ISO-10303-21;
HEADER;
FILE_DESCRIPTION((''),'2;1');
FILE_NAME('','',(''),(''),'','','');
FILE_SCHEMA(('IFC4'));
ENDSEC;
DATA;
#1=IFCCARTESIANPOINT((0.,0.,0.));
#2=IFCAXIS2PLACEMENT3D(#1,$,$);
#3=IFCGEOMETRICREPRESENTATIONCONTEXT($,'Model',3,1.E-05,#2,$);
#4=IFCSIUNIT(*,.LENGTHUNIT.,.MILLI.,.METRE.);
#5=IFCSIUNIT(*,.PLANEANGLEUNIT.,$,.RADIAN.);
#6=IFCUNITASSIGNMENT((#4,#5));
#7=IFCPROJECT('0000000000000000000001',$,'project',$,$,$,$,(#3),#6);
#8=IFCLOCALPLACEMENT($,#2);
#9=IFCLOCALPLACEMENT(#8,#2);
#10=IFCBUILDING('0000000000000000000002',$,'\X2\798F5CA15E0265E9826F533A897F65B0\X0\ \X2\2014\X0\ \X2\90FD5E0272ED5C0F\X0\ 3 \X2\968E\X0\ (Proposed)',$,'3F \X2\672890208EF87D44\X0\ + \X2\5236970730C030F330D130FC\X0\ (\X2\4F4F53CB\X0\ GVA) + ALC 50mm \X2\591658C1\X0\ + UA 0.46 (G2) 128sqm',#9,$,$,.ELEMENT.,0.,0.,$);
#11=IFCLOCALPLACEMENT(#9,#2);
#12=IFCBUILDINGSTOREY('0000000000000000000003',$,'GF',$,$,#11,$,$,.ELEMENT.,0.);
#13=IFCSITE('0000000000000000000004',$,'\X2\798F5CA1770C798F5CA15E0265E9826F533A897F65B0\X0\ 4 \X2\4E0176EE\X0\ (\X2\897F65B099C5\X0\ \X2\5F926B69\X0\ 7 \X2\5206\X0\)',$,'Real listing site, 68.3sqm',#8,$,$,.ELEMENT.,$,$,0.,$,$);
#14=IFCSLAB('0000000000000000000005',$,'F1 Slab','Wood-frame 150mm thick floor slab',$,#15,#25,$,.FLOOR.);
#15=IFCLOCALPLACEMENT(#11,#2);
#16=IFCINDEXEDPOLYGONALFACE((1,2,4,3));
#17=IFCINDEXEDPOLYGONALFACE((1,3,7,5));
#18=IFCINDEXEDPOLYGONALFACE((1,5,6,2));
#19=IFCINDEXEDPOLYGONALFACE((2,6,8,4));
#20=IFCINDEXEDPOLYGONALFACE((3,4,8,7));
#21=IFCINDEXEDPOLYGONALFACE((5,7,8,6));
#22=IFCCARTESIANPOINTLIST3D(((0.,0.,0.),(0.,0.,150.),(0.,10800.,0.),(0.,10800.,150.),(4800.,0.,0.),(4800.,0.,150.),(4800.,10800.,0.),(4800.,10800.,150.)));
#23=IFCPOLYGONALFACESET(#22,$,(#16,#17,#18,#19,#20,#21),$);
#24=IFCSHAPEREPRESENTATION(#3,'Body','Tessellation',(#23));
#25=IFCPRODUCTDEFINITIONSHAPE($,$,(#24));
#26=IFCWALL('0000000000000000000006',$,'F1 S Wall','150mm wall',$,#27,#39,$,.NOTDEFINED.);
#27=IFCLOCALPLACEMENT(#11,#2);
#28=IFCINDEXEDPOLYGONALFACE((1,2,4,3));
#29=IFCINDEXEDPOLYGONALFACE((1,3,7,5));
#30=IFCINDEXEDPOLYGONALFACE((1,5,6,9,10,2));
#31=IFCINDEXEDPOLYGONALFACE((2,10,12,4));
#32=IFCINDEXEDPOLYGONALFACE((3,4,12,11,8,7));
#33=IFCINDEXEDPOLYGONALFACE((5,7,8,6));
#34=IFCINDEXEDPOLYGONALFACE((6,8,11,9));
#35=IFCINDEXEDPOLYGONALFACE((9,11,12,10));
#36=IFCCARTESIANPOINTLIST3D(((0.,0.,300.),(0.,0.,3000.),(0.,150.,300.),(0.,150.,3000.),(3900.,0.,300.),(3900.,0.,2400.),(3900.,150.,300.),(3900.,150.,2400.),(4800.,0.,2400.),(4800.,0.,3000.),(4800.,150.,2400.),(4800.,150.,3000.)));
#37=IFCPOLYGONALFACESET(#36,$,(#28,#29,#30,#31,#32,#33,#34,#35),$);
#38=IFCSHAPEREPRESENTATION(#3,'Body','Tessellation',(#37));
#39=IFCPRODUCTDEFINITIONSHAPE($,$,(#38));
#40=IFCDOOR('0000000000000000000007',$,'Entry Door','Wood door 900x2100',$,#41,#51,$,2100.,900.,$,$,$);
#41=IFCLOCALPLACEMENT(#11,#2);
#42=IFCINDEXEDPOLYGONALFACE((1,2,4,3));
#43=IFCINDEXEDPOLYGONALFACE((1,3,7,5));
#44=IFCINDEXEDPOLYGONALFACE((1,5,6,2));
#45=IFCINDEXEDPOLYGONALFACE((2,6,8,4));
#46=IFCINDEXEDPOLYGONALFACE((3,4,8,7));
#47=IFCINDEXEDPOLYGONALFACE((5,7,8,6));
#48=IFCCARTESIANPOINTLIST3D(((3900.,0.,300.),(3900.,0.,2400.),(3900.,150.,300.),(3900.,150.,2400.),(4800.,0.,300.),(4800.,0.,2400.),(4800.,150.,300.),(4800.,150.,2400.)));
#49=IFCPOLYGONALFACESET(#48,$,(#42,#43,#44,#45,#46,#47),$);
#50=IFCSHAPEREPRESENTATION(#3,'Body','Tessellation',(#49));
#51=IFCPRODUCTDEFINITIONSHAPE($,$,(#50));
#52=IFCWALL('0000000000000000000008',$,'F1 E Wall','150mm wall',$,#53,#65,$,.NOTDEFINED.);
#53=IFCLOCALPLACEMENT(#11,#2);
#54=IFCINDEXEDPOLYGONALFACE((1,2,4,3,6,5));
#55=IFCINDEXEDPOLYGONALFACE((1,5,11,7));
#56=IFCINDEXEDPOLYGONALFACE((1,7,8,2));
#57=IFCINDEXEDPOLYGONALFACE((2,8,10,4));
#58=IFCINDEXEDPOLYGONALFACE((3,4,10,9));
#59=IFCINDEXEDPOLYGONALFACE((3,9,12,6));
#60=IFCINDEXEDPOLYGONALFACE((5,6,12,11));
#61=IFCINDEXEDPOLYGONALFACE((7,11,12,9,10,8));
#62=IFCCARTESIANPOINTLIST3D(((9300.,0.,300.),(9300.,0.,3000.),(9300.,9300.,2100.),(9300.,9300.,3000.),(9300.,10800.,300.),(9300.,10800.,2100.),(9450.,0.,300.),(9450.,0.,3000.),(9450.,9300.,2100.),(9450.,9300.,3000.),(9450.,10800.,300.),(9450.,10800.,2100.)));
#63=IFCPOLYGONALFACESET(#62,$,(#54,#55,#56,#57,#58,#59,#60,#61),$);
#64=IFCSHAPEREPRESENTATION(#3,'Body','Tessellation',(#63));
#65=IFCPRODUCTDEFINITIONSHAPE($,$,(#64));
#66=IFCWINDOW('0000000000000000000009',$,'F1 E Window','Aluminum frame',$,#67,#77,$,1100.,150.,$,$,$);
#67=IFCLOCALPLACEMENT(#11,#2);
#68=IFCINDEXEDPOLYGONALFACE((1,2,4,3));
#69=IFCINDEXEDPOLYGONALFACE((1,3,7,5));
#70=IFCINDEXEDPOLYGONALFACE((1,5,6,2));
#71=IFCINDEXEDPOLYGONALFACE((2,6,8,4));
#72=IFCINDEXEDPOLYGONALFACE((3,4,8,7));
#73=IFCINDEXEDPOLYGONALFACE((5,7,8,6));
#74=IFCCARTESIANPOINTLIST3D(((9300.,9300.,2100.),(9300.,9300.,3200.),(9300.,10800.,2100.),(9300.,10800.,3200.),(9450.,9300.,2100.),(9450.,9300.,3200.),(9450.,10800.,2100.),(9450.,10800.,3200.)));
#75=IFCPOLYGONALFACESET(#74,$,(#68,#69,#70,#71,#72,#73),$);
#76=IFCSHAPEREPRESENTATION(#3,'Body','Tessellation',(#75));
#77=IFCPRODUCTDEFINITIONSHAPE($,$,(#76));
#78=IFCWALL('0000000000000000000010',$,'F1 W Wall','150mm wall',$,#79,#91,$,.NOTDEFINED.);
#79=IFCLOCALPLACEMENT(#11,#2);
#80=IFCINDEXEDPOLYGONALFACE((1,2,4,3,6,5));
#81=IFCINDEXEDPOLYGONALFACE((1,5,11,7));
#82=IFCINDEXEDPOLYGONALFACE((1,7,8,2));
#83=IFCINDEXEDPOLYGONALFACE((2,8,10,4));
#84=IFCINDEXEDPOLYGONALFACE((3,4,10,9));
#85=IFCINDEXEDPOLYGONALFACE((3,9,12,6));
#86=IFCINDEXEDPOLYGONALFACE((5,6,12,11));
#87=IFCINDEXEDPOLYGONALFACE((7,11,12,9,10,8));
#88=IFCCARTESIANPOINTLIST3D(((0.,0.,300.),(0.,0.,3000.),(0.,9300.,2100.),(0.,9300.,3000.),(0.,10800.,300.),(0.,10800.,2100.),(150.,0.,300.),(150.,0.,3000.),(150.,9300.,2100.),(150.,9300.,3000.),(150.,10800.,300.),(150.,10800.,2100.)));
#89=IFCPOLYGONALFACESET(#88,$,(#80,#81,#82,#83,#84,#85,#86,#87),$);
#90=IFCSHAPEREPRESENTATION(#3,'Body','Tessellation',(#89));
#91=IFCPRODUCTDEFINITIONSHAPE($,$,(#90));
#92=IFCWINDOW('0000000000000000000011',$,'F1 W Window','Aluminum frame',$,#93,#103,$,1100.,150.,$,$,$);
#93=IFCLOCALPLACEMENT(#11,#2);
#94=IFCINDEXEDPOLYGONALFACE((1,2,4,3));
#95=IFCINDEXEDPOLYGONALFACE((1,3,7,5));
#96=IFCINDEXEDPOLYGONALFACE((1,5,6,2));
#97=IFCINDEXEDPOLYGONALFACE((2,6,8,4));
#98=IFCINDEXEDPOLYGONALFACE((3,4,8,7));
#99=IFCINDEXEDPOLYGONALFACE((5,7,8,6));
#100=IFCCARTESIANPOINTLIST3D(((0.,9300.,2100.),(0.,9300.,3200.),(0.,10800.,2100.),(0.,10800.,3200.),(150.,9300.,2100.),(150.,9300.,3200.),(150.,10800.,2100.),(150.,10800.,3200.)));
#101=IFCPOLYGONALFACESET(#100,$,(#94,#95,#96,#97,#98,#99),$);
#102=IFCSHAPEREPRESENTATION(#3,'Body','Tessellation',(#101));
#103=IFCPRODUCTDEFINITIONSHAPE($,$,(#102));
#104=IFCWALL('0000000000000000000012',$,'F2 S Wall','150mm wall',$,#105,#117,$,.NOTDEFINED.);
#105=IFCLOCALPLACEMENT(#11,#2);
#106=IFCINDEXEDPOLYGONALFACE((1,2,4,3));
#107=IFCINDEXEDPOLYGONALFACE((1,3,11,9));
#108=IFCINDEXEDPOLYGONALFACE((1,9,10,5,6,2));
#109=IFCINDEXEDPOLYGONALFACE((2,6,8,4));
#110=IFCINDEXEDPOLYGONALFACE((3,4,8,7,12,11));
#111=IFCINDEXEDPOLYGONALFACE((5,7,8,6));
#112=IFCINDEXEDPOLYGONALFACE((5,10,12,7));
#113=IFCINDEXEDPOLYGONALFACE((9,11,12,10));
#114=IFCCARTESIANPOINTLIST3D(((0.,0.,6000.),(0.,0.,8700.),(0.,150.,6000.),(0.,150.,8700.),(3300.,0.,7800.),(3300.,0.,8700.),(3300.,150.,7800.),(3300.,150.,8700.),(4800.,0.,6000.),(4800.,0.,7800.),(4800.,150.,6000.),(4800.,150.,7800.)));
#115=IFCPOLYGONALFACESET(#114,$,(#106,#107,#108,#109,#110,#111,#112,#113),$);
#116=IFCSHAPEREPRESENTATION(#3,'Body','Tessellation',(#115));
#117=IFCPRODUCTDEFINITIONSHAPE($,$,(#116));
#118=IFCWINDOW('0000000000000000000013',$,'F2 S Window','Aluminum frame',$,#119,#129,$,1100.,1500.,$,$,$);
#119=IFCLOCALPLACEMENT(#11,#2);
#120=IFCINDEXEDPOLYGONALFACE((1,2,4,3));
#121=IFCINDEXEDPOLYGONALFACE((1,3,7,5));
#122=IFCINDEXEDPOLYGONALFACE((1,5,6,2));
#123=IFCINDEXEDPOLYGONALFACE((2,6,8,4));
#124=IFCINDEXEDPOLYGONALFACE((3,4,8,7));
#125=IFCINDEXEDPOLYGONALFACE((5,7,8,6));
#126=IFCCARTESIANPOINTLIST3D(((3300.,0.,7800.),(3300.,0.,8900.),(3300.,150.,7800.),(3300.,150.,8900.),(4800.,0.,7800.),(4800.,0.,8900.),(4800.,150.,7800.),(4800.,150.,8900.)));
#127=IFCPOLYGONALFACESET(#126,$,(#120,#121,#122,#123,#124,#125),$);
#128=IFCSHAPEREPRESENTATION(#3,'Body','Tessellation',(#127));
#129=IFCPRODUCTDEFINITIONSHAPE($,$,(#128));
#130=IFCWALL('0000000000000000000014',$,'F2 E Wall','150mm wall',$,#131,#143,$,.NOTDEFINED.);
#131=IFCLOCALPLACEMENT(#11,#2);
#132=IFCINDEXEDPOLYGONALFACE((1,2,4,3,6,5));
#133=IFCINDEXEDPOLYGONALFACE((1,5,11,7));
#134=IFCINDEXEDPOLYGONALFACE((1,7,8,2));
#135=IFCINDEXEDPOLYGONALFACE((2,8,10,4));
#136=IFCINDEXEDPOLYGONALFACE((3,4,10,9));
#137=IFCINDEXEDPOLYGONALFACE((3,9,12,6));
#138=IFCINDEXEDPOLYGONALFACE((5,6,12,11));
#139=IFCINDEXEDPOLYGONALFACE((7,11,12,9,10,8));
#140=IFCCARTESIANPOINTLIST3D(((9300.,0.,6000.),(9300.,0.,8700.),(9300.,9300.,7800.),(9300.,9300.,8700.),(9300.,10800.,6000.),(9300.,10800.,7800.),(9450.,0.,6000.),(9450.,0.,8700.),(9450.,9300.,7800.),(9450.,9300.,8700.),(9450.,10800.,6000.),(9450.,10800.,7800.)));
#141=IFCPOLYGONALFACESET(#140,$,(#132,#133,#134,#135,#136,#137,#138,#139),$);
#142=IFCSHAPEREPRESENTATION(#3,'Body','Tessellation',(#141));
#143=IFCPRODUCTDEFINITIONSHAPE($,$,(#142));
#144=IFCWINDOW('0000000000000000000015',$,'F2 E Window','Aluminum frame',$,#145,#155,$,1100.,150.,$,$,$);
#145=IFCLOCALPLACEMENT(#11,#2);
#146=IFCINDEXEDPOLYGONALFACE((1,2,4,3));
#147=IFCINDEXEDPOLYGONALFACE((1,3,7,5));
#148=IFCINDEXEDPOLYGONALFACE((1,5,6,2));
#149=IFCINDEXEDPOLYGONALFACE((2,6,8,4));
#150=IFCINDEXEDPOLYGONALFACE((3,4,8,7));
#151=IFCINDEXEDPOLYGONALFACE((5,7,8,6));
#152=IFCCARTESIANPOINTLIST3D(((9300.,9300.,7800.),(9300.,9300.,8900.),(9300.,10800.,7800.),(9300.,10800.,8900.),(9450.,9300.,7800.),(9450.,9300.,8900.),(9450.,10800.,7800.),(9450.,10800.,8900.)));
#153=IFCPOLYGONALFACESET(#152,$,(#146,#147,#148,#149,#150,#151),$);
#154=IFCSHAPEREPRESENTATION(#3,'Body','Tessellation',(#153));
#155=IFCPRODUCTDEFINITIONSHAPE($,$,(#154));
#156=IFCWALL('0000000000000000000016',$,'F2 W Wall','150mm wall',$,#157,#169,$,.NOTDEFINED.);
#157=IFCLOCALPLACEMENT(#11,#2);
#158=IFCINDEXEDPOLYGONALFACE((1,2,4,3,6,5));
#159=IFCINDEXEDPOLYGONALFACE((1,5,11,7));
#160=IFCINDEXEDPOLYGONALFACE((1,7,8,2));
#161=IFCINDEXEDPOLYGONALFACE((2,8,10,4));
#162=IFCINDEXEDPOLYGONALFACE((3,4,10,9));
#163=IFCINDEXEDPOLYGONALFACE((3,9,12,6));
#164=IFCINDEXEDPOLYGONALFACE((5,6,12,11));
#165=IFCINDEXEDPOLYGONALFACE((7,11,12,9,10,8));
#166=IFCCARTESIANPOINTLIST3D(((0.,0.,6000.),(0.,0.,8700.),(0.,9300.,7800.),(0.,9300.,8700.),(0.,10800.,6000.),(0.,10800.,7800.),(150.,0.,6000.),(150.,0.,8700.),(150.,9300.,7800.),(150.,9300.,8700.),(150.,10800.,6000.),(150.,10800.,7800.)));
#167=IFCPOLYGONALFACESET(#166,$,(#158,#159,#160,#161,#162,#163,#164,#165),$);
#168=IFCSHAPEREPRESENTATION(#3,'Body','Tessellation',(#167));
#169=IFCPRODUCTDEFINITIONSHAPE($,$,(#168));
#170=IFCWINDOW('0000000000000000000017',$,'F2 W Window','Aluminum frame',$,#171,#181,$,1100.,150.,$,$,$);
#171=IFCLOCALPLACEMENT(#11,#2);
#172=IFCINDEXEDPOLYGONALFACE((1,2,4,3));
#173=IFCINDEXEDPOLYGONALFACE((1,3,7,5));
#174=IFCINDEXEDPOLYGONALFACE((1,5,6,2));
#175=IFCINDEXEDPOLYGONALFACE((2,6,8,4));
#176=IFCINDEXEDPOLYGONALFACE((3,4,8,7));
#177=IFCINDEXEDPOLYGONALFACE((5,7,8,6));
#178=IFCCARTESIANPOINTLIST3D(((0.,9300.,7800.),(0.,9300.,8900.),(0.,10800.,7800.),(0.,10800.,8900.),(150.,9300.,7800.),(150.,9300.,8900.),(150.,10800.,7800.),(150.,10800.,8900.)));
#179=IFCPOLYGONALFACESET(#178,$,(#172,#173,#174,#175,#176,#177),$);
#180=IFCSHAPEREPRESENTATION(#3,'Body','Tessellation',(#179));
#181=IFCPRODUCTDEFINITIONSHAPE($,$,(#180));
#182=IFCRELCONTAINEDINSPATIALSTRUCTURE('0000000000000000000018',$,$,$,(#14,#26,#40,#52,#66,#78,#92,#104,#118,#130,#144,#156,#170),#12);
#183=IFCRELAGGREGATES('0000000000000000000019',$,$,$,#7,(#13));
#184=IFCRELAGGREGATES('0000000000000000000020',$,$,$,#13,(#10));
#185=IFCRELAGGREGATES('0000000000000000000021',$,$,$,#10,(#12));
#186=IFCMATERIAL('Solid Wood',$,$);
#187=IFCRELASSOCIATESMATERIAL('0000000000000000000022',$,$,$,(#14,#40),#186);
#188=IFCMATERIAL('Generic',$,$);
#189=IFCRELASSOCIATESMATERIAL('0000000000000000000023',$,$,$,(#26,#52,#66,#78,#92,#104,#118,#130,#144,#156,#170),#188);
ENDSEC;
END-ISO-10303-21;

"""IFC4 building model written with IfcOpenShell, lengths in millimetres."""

from ifc_helpers import new_model, si_unit, frame, frame_2d, origin, place, context, project, spatial, rectangle, extrude, material, element, fill, save


model = new_model("IFC4")

# Units and contexts
model_context = context("Model", 3, precision=1e-05, world=origin())
ifc_project = project(units=[si_unit("LENGTHUNIT", "METRE", prefix="MILLI"), si_unit("PLANEANGLEUNIT", "RADIAN")], contexts=[model_context])

# Site, building, storey
site_placement = place(None, origin())
site = spatial("IfcSite", under=ifc_project, at=site_placement, Name="福岡県福岡市早良区西新 4 丁目 (西新駅 徒歩 7 分)", ObjectType="Real listing site, 68.3sqm", CompositionType="ELEMENT", RefElevation=0.0)
building_placement = place(site_placement, origin())
building = spatial("IfcBuilding", under=site, at=building_placement, Name="福岡市早良区西新 — 都市狭小 3 階 (Proposed)", ObjectType="3F 木造軸組 + 制震ダンパー (住友 GVA) + ALC 50mm 外壁 + UA 0.46 (G2) 128sqm", CompositionType="ELEMENT", ElevationOfRefHeight=0.0, ElevationOfTerrain=0.0)
storey_placement = place(building_placement, origin())
storey = spatial("IfcBuildingStorey", under=building, at=storey_placement, Name="GF", CompositionType="ELEMENT", Elevation=0.0)

# Slab
ifc_material_1 = material(Name="Solid Wood")
slab_1_placement = place(storey_placement, origin())
element("IfcSlab", 1, at=slab_1_placement, inside=storey, material=ifc_material_1, Name="F1 Slab", Description="Wood-frame 150mm thick floor slab", PredefinedType="FLOOR", context=model_context, shape_type="SweptSolid", body=[
    extrude(rectangle(XDim=4800.0, YDim=10800.0, at=frame_2d((2400.0, 5400.0))), origin(), (0.0, 0.0, 1.0), 150.0),
])

# Wall, opening, door
ifc_material_2 = material(Name="Generic")
wall_1_placement = place(storey_placement, frame((0.0, 0.0, 150.0)))
wall_1 = element("IfcWall", 2, at=wall_1_placement, inside=storey, material=ifc_material_2, Name="F1 S Wall", Description="150mm wall", PredefinedType="NOTDEFINED", context=model_context, shape_type="SweptSolid", body=[
    extrude(rectangle(XDim=4800.0, YDim=150.0, at=frame_2d((2400.0, 75.0))), frame((0.0, 0.0, 150.0)), (0.0, 0.0, 1.0), 2700.0),
])
opening_1_placement = place(storey_placement, frame((1950.0, 0.0, 150.0)))
opening_1 = element("IfcOpeningElement", 3, at=opening_1_placement, cuts=wall_1, PredefinedType="NOTDEFINED", context=model_context, shape_type="SweptSolid", body=[
    extrude(rectangle(XDim=900.0, YDim=150.0, at=frame_2d((450.0, 75.0))), frame((1950.0, 0.0, 150.0)), (0.0, 0.0, 1.0), 2100.0),
])
door_placement = place(storey_placement, frame((1950.0, 0.0, 150.0)))
door = element("IfcDoor", 4, at=door_placement, inside=storey, material=ifc_material_1, Name="Entry Door", Description="Wood door 900x2100", OverallHeight=2100.0, OverallWidth=900.0, context=model_context, shape_type="SweptSolid", body=[
    extrude(rectangle(XDim=900.0, YDim=150.0, at=frame_2d((450.0, 75.0))), frame((1950.0, 0.0, 150.0)), (0.0, 0.0, 1.0), 2100.0),
])
fill(opening_1, door)

# Walls, openings, windows
wall_2_placement = place(storey_placement, frame((4650.0, 0.0, 150.0)))
wall_2 = element("IfcWall", 5, at=wall_2_placement, inside=storey, material=ifc_material_2, Name="F1 E Wall", Description="150mm wall", PredefinedType="NOTDEFINED", context=model_context, shape_type="SweptSolid", body=[
    extrude(rectangle(XDim=150.0, YDim=10800.0, at=frame_2d((75.0, 5400.0))), frame((4650.0, 0.0, 150.0)), (0.0, 0.0, 1.0), 2700.0),
])
opening_2_placement = place(storey_placement, frame((4650.0, 4650.0, 1050.0)))
opening_2 = element("IfcOpeningElement", 6, at=opening_2_placement, cuts=wall_2, PredefinedType="NOTDEFINED", context=model_context, shape_type="SweptSolid", body=[
    extrude(rectangle(XDim=150.0, YDim=1500.0, at=frame_2d((75.0, 750.0))), frame((4650.0, 4650.0, 1050.0)), (0.0, 0.0, 1.0), 1100.0),
])
window_1_placement = place(storey_placement, frame((4650.0, 4650.0, 1050.0)))
window_1 = element("IfcWindow", 7, at=window_1_placement, inside=storey, material=ifc_material_2, Name="F1 E Window", Description="Aluminum frame", OverallHeight=1100.0, OverallWidth=150.0, context=model_context, shape_type="SweptSolid", body=[
    extrude(rectangle(XDim=150.0, YDim=1500.0, at=frame_2d((75.0, 750.0))), frame((4650.0, 4650.0, 1050.0)), (0.0, 0.0, 1.0), 1100.0),
])
fill(opening_2, window_1)
wall_3_placement = place(storey_placement, frame((0.0, 0.0, 150.0)))
wall_3 = element("IfcWall", 8, at=wall_3_placement, inside=storey, material=ifc_material_2, Name="F1 W Wall", Description="150mm wall", PredefinedType="NOTDEFINED", context=model_context, shape_type="SweptSolid", body=[
    extrude(rectangle(XDim=150.0, YDim=10800.0, at=frame_2d((75.0, 5400.0))), frame((0.0, 0.0, 150.0)), (0.0, 0.0, 1.0), 2700.0),
])
opening_3_placement = place(storey_placement, frame((0.0, 4650.0, 1050.0)))
opening_3 = element("IfcOpeningElement", 9, at=opening_3_placement, cuts=wall_3, PredefinedType="NOTDEFINED", context=model_context, shape_type="SweptSolid", body=[
    extrude(rectangle(XDim=150.0, YDim=1500.0, at=frame_2d((75.0, 750.0))), frame((0.0, 4650.0, 1050.0)), (0.0, 0.0, 1.0), 1100.0),
])
window_2_placement = place(storey_placement, frame((0.0, 4650.0, 1050.0)))
window_2 = element("IfcWindow", 10, at=window_2_placement, inside=storey, material=ifc_material_2, Name="F1 W Window", Description="Aluminum frame", OverallHeight=1100.0, OverallWidth=150.0, context=model_context, shape_type="SweptSolid", body=[
    extrude(rectangle(XDim=150.0, YDim=1500.0, at=frame_2d((75.0, 750.0))), frame((0.0, 4650.0, 1050.0)), (0.0, 0.0, 1.0), 1100.0),
])
fill(opening_3, window_2)
wall_4_placement = place(storey_placement, frame((0.0, 0.0, 3000.0)))
wall_4 = element("IfcWall", 11, at=wall_4_placement, inside=storey, material=ifc_material_2, Name="F2 S Wall", Description="150mm wall", PredefinedType="NOTDEFINED", context=model_context, shape_type="SweptSolid", body=[
    extrude(rectangle(XDim=4800.0, YDim=150.0, at=frame_2d((2400.0, 75.0))), frame((0.0, 0.0, 3000.0)), (0.0, 0.0, 1.0), 2700.0),
])
opening_4_placement = place(storey_placement, frame((1650.0, 0.0, 3900.0)))
opening_4 = element("IfcOpeningElement", 12, at=opening_4_placement, cuts=wall_4, PredefinedType="NOTDEFINED", context=model_context, shape_type="SweptSolid", body=[
    extrude(rectangle(XDim=1500.0, YDim=150.0, at=frame_2d((750.0, 75.0))), frame((1650.0, 0.0, 3900.0)), (0.0, 0.0, 1.0), 1100.0),
])
window_3_placement = place(storey_placement, frame((1650.0, 0.0, 3900.0)))
window_3 = element("IfcWindow", 13, at=window_3_placement, inside=storey, material=ifc_material_2, Name="F2 S Window", Description="Aluminum frame", OverallHeight=1100.0, OverallWidth=1500.0, context=model_context, shape_type="SweptSolid", body=[
    extrude(rectangle(XDim=1500.0, YDim=150.0, at=frame_2d((750.0, 75.0))), frame((1650.0, 0.0, 3900.0)), (0.0, 0.0, 1.0), 1100.0),
])
fill(opening_4, window_3)
wall_5_placement = place(storey_placement, frame((4650.0, 0.0, 3000.0)))
wall_5 = element("IfcWall", 14, at=wall_5_placement, inside=storey, material=ifc_material_2, Name="F2 E Wall", Description="150mm wall", PredefinedType="NOTDEFINED", context=model_context, shape_type="SweptSolid", body=[
    extrude(rectangle(XDim=150.0, YDim=10800.0, at=frame_2d((75.0, 5400.0))), frame((4650.0, 0.0, 3000.0)), (0.0, 0.0, 1.0), 2700.0),
])
opening_5_placement = place(storey_placement, frame((4650.0, 4650.0, 3900.0)))
opening_5 = element("IfcOpeningElement", 15, at=opening_5_placement, cuts=wall_5, PredefinedType="NOTDEFINED", context=model_context, shape_type="SweptSolid", body=[
    extrude(rectangle(XDim=150.0, YDim=1500.0, at=frame_2d((75.0, 750.0))), frame((4650.0, 4650.0, 3900.0)), (0.0, 0.0, 1.0), 1100.0),
])
window_4_placement = place(storey_placement, frame((4650.0, 4650.0, 3900.0)))
window_4 = element("IfcWindow", 16, at=window_4_placement, inside=storey, material=ifc_material_2, Name="F2 E Window", Description="Aluminum frame", OverallHeight=1100.0, OverallWidth=150.0, context=model_context, shape_type="SweptSolid", body=[
    extrude(rectangle(XDim=150.0, YDim=1500.0, at=frame_2d((75.0, 750.0))), frame((4650.0, 4650.0, 3900.0)), (0.0, 0.0, 1.0), 1100.0),
])
fill(opening_5, window_4)
wall_6_placement = place(storey_placement, frame((0.0, 0.0, 3000.0)))
wall_6 = element("IfcWall", 17, at=wall_6_placement, inside=storey, material=ifc_material_2, Name="F2 W Wall", Description="150mm wall", PredefinedType="NOTDEFINED", context=model_context, shape_type="SweptSolid", body=[
    extrude(rectangle(XDim=150.0, YDim=10800.0, at=frame_2d((75.0, 5400.0))), frame((0.0, 0.0, 3000.0)), (0.0, 0.0, 1.0), 2700.0),
])
opening_6_placement = place(storey_placement, frame((0.0, 4650.0, 3900.0)))
opening_6 = element("IfcOpeningElement", 18, at=opening_6_placement, cuts=wall_6, PredefinedType="NOTDEFINED", context=model_context, shape_type="SweptSolid", body=[
    extrude(rectangle(XDim=150.0, YDim=1500.0, at=frame_2d((75.0, 750.0))), frame((0.0, 4650.0, 3900.0)), (0.0, 0.0, 1.0), 1100.0),
])
window_5_placement = place(storey_placement, frame((0.0, 4650.0, 3900.0)))
window_5 = element("IfcWindow", 19, at=window_5_placement, inside=storey, material=ifc_material_2, Name="F2 W Window", Description="Aluminum frame", OverallHeight=1100.0, OverallWidth=150.0, context=model_context, shape_type="SweptSolid", body=[
    extrude(rectangle(XDim=150.0, YDim=1500.0, at=frame_2d((75.0, 750.0))), frame((0.0, 4650.0, 3900.0)), (0.0, 0.0, 1.0), 1100.0),
])
fill(opening_6, window_5)

save(model, "model.ifc")
